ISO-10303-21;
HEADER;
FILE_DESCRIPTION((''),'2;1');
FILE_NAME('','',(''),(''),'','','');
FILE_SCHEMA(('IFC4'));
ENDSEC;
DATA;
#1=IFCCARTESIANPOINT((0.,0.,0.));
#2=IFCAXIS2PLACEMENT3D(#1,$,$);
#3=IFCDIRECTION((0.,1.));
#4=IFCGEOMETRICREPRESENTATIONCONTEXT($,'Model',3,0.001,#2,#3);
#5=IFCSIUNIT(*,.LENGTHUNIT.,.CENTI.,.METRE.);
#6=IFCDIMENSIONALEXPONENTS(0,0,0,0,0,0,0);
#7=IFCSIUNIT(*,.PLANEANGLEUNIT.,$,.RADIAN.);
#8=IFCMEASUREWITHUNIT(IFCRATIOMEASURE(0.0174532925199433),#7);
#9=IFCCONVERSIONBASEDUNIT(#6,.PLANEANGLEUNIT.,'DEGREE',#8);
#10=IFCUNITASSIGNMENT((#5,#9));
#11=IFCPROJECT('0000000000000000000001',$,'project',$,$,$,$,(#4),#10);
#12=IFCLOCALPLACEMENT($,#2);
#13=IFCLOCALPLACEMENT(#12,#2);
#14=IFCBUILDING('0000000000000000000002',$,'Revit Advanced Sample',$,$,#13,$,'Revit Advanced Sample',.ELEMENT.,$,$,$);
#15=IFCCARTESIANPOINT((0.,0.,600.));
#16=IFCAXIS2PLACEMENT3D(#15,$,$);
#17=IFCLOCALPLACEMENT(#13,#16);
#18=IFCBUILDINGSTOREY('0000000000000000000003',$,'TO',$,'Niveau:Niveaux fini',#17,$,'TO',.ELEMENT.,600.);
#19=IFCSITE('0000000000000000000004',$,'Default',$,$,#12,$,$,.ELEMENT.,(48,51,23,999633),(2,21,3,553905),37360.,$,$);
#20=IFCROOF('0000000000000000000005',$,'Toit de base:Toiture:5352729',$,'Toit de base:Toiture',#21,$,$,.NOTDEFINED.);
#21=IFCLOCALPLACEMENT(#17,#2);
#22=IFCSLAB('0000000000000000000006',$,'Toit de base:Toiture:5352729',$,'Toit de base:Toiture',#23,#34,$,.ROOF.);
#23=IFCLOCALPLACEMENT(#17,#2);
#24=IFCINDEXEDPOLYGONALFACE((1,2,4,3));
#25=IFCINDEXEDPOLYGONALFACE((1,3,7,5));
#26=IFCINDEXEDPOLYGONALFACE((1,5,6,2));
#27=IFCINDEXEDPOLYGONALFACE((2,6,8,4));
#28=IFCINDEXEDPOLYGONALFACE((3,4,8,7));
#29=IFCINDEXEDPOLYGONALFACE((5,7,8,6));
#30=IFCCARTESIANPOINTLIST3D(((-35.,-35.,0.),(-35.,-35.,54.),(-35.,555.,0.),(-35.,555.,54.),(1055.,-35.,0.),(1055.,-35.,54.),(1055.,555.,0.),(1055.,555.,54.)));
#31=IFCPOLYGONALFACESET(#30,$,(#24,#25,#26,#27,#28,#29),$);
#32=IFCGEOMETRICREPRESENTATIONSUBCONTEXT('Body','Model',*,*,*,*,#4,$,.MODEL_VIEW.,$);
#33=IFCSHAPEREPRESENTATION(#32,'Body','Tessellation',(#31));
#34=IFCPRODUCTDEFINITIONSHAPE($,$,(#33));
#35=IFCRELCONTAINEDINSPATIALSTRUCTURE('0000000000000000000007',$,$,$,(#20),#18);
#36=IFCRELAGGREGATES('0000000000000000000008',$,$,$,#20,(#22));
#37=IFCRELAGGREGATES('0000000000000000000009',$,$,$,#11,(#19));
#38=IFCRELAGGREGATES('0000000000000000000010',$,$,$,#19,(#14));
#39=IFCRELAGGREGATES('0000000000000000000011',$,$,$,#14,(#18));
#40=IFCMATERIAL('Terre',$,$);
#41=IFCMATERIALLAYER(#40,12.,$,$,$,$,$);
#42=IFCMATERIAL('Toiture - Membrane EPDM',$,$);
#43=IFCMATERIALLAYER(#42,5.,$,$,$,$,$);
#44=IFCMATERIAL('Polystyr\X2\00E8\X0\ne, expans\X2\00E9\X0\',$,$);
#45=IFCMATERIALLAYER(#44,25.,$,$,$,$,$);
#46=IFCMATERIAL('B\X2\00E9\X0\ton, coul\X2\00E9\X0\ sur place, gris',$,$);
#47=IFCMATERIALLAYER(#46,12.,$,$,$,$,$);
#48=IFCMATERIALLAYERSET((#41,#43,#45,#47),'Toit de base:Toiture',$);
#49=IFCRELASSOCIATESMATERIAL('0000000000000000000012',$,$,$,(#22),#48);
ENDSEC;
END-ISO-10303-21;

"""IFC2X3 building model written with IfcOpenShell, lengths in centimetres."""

from ifc_helpers import new_model, entity, si_unit, converted_unit, direction, frame, frame_2d, origin, place, context, subcontext, project, spatial, rectangle, extrude, material, layer, layer_set, element, aggregate, save


model = new_model("IFC2X3")

# Units and contexts
model_context = context("Model", 3, precision=0.001, world=origin(), true_north=direction((0.0, 1.0)))
body_context = subcontext(model_context, "Body", "Model", "MODEL_VIEW")
ifc_project = project(units=[si_unit("LENGTHUNIT", "METRE", prefix="CENTI"), converted_unit("PLANEANGLEUNIT", "DEGREE", entity("IfcRatioMeasure", 0.0174532925199433), si_unit("PLANEANGLEUNIT", "RADIAN"), dimensions=[0, 0, 0, 0, 0, 0, 0])], contexts=[model_context])

# Site, building, storey
site_placement = place(None, origin())
site = spatial("IfcSite", under=ifc_project, at=site_placement, Name="Default", CompositionType="ELEMENT", RefLatitude=(48, 51, 23, 999633), RefLongitude=(2, 21, 3, 553905), RefElevation=37360.0)
building_placement = place(site_placement, origin())
building = spatial("IfcBuilding", under=site, at=building_placement, Name="Revit Advanced Sample", LongName="Revit Advanced Sample", CompositionType="ELEMENT")
storey_placement = place(building_placement, frame((0.0, 0.0, 600.0)))
storey = spatial("IfcBuildingStorey", under=building, at=storey_placement, Name="TO", ObjectType="Niveau:Niveaux fini", LongName="TO", CompositionType="ELEMENT", Elevation=600.0)

# Roof, slab
roof_placement = place(storey_placement, frame((-35.0, -35.0, 0.0)))
roof = element("IfcRoof", 1, at=roof_placement, inside=storey, Name="Toit de base:Toiture:5352729", ObjectType="Toit de base:Toiture", ShapeType="NOTDEFINED")
ifc_material_1 = material(Name="Terre")
ifc_layer_1 = layer(ifc_material_1, 12.0)
ifc_material_2 = material(Name="Toiture - Membrane EPDM")
ifc_layer_2 = layer(ifc_material_2, 5.0)
ifc_material_3 = material(Name="Polystyrène, expansé")
ifc_layer_3 = layer(ifc_material_3, 25.0)
ifc_material_4 = material(Name="Béton, coulé sur place, gris")
ifc_layer_4 = layer(ifc_material_4, 12.0)
ifc_layer_set = layer_set([ifc_layer_1, ifc_layer_2, ifc_layer_3, ifc_layer_4], Name="Toit de base:Toiture")
slab_placement = place(roof_placement, origin())
slab = element("IfcSlab", 2, at=slab_placement, material=ifc_layer_set, Name="Toit de base:Toiture:5352729", ObjectType="Toit de base:Toiture", PredefinedType="ROOF", context=body_context, shape_type="SweptSolid", body=[
    extrude(rectangle(XDim=1090.0, YDim=590.0, at=frame_2d((0.0, 0.0), x_axis=(1.0, 0.0))), frame((545.0, 295.0, 0.0)), (0.0, 0.0, 1.0), 54.0),
])
aggregate(roof, [slab])

save(model, "model.ifc")
